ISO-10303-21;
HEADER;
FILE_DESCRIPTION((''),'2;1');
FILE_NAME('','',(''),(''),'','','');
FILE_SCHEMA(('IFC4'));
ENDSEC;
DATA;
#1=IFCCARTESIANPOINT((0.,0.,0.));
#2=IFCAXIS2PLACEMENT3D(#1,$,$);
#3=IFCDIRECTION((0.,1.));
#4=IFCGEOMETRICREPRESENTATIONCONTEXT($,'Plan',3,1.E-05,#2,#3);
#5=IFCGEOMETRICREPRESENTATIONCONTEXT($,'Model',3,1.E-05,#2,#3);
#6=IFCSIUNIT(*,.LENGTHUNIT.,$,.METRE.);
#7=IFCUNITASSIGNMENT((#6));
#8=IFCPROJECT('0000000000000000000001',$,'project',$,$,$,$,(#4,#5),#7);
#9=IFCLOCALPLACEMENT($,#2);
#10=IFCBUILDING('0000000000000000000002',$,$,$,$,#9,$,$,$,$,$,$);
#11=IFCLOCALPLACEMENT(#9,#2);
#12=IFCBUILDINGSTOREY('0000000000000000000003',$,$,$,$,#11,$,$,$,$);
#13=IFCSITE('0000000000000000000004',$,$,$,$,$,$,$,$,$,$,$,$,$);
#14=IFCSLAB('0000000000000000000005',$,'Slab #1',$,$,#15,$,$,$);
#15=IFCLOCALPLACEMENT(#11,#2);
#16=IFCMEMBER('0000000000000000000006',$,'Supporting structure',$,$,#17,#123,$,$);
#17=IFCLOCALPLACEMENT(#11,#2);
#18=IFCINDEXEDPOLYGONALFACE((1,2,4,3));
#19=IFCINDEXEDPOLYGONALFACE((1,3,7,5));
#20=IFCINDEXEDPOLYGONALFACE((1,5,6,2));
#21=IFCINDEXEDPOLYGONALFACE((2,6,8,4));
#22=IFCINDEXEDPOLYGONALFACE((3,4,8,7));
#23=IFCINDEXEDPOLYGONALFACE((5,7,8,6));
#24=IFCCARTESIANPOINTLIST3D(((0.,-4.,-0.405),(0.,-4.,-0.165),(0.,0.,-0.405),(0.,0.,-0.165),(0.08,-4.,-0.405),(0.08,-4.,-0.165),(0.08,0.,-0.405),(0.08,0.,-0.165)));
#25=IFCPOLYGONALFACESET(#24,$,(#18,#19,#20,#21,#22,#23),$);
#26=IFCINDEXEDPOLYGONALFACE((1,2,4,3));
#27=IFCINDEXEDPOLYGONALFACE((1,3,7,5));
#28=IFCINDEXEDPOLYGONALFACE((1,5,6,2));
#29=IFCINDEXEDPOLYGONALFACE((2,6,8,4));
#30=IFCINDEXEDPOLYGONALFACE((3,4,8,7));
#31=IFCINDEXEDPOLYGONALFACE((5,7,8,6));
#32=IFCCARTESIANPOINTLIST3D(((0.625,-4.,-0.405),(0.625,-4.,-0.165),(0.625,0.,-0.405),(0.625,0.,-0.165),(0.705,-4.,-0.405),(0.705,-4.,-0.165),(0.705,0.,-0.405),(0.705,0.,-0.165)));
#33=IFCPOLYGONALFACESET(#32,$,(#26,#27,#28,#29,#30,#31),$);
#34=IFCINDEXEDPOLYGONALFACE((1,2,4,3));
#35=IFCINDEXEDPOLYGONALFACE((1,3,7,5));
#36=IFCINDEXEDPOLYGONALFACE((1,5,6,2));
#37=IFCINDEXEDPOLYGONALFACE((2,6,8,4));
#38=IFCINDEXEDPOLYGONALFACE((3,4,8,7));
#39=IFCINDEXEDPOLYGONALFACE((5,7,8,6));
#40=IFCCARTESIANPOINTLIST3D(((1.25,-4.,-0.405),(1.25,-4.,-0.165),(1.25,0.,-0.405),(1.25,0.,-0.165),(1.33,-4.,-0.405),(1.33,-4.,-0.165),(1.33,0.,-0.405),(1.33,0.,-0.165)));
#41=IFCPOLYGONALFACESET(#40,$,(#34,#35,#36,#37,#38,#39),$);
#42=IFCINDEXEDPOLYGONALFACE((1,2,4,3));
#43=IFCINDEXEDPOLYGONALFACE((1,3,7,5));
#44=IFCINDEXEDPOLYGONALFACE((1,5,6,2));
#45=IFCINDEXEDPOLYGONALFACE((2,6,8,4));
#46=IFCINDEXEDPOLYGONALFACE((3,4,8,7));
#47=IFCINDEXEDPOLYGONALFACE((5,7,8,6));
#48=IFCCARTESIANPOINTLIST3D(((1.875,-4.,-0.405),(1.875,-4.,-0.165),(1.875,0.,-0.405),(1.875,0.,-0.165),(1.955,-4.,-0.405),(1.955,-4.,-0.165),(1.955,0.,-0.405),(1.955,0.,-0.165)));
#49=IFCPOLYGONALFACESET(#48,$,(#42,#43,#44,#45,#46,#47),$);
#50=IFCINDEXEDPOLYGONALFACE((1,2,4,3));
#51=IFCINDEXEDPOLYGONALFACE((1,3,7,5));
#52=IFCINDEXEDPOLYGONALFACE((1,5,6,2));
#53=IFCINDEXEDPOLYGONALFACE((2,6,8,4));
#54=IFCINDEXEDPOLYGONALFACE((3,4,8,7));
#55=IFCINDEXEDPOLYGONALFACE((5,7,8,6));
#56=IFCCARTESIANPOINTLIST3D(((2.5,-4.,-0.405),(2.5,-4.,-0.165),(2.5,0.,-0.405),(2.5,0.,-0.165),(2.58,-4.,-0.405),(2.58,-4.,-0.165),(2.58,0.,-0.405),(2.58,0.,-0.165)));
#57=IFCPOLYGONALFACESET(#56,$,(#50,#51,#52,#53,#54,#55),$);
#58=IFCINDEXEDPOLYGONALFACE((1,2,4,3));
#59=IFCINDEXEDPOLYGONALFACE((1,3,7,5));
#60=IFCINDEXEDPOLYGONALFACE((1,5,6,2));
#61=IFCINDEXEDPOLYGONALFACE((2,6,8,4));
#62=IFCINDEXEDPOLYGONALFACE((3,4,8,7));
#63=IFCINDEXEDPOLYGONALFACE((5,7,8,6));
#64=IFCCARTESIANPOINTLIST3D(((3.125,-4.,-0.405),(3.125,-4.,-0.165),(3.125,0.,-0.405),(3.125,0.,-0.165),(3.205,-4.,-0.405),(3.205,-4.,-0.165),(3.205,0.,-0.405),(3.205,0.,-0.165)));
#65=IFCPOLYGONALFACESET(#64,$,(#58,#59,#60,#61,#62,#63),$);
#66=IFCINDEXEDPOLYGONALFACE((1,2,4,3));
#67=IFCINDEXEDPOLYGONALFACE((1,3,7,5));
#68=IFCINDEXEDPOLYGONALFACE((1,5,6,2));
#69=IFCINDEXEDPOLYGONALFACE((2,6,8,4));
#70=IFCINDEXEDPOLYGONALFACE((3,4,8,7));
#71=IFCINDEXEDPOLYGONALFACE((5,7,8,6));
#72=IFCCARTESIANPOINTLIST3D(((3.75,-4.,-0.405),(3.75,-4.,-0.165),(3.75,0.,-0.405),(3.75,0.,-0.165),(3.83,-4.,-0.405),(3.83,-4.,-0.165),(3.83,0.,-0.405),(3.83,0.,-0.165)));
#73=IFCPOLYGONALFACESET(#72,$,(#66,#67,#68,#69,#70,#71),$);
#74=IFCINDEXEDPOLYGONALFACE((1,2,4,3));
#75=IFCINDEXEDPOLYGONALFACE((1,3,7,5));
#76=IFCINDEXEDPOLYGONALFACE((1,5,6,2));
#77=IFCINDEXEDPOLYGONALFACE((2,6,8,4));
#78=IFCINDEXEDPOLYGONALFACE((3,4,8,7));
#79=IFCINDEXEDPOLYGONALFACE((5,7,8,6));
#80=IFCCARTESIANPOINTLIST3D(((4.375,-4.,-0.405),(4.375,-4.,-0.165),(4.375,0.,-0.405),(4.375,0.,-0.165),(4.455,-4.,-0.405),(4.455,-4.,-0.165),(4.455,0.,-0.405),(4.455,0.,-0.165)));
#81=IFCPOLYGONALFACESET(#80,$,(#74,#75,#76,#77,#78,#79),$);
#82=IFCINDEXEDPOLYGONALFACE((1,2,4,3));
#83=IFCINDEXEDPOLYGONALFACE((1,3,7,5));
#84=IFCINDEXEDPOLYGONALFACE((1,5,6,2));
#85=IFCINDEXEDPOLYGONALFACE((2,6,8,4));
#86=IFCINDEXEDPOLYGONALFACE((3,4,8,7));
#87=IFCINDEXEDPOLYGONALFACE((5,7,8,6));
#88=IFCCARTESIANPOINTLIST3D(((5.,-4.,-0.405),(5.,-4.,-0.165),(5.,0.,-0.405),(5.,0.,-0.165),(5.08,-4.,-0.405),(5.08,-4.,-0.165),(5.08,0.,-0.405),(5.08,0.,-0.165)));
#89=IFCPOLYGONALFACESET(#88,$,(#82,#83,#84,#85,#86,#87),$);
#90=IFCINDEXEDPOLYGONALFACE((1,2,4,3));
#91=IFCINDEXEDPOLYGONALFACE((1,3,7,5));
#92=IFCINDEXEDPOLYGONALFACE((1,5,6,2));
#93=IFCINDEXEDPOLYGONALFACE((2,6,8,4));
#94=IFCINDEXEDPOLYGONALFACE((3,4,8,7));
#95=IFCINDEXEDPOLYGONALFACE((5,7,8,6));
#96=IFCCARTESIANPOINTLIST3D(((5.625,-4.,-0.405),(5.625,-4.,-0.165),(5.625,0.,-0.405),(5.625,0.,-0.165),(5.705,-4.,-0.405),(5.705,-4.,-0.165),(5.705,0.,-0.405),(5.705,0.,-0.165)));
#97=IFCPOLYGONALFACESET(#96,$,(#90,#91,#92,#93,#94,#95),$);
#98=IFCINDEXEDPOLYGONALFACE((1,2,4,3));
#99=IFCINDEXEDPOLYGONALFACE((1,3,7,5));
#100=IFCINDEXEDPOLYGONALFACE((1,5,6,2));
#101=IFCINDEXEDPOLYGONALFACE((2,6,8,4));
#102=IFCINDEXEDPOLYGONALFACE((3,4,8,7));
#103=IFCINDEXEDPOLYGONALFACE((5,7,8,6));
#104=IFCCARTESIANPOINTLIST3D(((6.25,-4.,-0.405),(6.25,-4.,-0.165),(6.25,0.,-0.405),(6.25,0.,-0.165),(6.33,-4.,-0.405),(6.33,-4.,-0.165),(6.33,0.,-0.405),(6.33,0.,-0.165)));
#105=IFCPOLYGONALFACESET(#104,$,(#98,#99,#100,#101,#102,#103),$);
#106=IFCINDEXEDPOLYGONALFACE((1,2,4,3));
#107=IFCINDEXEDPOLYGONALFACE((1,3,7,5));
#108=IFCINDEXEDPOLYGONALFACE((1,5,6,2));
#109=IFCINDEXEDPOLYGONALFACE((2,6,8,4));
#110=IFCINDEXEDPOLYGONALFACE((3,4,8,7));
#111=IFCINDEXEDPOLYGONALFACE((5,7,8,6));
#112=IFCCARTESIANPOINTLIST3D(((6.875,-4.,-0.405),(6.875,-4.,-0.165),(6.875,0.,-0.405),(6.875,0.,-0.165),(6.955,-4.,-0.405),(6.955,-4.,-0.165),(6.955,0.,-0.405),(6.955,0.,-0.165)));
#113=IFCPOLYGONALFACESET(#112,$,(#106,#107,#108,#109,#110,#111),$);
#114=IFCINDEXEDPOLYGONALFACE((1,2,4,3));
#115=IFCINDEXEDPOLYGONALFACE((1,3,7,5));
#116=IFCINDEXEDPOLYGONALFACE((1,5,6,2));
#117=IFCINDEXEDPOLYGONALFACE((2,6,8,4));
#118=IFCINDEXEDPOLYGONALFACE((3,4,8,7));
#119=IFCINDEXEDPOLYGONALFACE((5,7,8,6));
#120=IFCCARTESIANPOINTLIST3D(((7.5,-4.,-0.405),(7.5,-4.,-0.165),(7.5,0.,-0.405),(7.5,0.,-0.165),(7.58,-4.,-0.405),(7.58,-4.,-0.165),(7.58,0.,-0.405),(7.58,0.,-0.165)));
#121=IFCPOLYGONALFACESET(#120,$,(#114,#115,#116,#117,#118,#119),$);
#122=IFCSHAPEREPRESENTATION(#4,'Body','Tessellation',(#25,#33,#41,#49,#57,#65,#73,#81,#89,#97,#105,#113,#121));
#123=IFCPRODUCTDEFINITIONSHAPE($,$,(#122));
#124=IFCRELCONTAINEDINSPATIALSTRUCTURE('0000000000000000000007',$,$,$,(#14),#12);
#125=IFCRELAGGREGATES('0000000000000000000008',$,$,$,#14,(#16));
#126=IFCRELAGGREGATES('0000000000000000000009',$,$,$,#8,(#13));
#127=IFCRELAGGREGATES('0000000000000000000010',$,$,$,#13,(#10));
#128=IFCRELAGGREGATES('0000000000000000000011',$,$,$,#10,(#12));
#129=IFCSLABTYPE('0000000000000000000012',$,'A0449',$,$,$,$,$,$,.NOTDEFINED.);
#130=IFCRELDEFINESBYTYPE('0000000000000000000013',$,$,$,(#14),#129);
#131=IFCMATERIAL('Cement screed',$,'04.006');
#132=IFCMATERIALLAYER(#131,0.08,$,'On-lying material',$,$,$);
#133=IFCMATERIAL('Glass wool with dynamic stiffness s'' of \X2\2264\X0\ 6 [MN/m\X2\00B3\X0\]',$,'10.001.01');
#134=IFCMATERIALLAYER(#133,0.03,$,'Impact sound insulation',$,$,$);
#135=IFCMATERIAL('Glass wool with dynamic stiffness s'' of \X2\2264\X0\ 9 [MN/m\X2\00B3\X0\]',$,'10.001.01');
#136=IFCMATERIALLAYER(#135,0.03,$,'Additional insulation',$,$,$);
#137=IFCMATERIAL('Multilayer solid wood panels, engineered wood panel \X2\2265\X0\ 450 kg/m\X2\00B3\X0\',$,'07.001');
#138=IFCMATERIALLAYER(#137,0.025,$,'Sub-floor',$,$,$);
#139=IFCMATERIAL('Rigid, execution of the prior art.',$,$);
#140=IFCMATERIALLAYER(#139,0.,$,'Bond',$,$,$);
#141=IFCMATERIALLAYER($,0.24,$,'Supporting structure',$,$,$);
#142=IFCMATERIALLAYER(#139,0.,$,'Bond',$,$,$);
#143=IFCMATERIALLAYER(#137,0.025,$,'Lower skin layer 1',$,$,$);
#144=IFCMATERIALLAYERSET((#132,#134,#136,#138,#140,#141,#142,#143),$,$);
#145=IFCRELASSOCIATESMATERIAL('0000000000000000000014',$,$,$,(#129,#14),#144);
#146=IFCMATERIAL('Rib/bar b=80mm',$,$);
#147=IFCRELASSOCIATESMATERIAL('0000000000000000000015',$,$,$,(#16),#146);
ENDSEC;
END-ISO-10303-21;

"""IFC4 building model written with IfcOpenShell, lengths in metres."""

from ifc_helpers import new_model, si_unit, direction, frame, frame_2d, origin, place, context, project, spatial, rectangle, extrude, material, layer, layer_set, type_object, element, aggregate, save


model = new_model("IFC4")

# Units and contexts
plan_context = context("Plan", 3, precision=1e-05, world=origin(), true_north=direction((0.0, 1.0)))
model_context = context("Model", 3, precision=1e-05, world=origin(), true_north=direction((0.0, 1.0)))
ifc_project = project(units=[si_unit("LENGTHUNIT", "METRE")], contexts=[plan_context, model_context])

# Site, building, storey
site = spatial("IfcSite", under=ifc_project)
building_placement = place(None, origin())
building = spatial("IfcBuilding", under=site, at=building_placement)
storey_placement = place(building_placement, origin())
storey = spatial("IfcBuildingStorey", under=building, at=storey_placement)

# Slab, member
ifc_material_1 = material(Name="Cement screed", Category="04.006")
ifc_layer_1 = layer(ifc_material_1, 0.08, Name="On-lying material")
ifc_material_2 = material(Name="Glass wool with dynamic stiffness s' of ≤ 6 [MN/m³]", Category="10.001.01")
ifc_layer_2 = layer(ifc_material_2, 0.03, Name="Impact sound insulation")
ifc_material_3 = material(Name="Glass wool with dynamic stiffness s' of ≤ 9 [MN/m³]", Category="10.001.01")
ifc_layer_3 = layer(ifc_material_3, 0.03, Name="Additional insulation")
ifc_material_4 = material(Name="Multilayer solid wood panels, engineered wood panel ≥ 450 kg/m³", Category="07.001")
ifc_layer_4 = layer(ifc_material_4, 0.025, Name="Sub-floor")
ifc_material_5 = material(Name="Rigid, execution of the prior art.")
ifc_layer_5 = layer(ifc_material_5, 0.0, Name="Bond")
ifc_layer_6 = layer(None, 0.24, Name="Supporting structure")
ifc_layer_7 = layer(ifc_material_5, 0.0, Name="Bond")
ifc_layer_8 = layer(ifc_material_4, 0.025, Name="Lower skin layer 1")
ifc_layer_set = layer_set([ifc_layer_1, ifc_layer_2, ifc_layer_3, ifc_layer_4, ifc_layer_5, ifc_layer_6, ifc_layer_7, ifc_layer_8])
slab_type = type_object("IfcSlabType", Name="A0449", PredefinedType="NOTDEFINED", material=ifc_layer_set)
slab_placement = place(None, frame((0.0, 0.0, 0.0), z_axis=(0.0, 0.0, -1.0), x_axis=(1.0, 0.0, 0.0)))
slab = element("IfcSlab", 1, at=slab_placement, inside=storey, type_object=slab_type, material=ifc_layer_set, Name="Slab #1")
ifc_material_6 = material(Name="Rib/bar b=80mm")
member_1_placement = place(slab_placement, origin())
member_1 = element("IfcMember", 2, at=member_1_placement, material=ifc_material_6, Name="Supporting structure", context=plan_context, shape_type="SweptSolid", body=[
    extrude(rectangle(XDim=0.08, YDim=0.24, at=frame_2d((0.04, 0.12), x_axis=(1.0, 0.0))), frame((0.0, 4.0, 0.165), z_axis=(0.0, -1.0, 0.0), x_axis=(1.0, 0.0, 0.0)), (0.0, 0.0, 1.0), 4.0),
    extrude(rectangle(XDim=0.08, YDim=0.24, at=frame_2d((0.04, 0.12), x_axis=(1.0, 0.0))), frame((0.625, 4.0, 0.165), z_axis=(0.0, -1.0, 0.0), x_axis=(1.0, 0.0, 0.0)), (0.0, 0.0, 1.0), 4.0),
    extrude(rectangle(XDim=0.08, YDim=0.24, at=frame_2d((0.04, 0.12), x_axis=(1.0, 0.0))), frame((1.25, 4.0, 0.165), z_axis=(0.0, -1.0, 0.0), x_axis=(1.0, 0.0, 0.0)), (0.0, 0.0, 1.0), 4.0),
    extrude(rectangle(XDim=0.08, YDim=0.24, at=frame_2d((0.04, 0.12), x_axis=(1.0, 0.0))), frame((1.875, 4.0, 0.165), z_axis=(0.0, -1.0, 0.0), x_axis=(1.0, 0.0, 0.0)), (0.0, 0.0, 1.0), 4.0),
    extrude(rectangle(XDim=0.08, YDim=0.24, at=frame_2d((0.04, 0.12), x_axis=(1.0, 0.0))), frame((2.5, 4.0, 0.165), z_axis=(0.0, -1.0, 0.0), x_axis=(1.0, 0.0, 0.0)), (0.0, 0.0, 1.0), 4.0),
    extrude(rectangle(XDim=0.08, YDim=0.24, at=frame_2d((0.04, 0.12), x_axis=(1.0, 0.0))), frame((3.125, 4.0, 0.165), z_axis=(0.0, -1.0, 0.0), x_axis=(1.0, 0.0, 0.0)), (0.0, 0.0, 1.0), 4.0),
    extrude(rectangle(XDim=0.08, YDim=0.24, at=frame_2d((0.04, 0.12), x_axis=(1.0, 0.0))), frame((3.75, 4.0, 0.165), z_axis=(0.0, -1.0, 0.0), x_axis=(1.0, 0.0, 0.0)), (0.0, 0.0, 1.0), 4.0),
    extrude(rectangle(XDim=0.08, YDim=0.24, at=frame_2d((0.04, 0.12), x_axis=(1.0, 0.0))), frame((4.375, 4.0, 0.165), z_axis=(0.0, -1.0, 0.0), x_axis=(1.0, 0.0, 0.0)), (0.0, 0.0, 1.0), 4.0),
    extrude(rectangle(XDim=0.08, YDim=0.24, at=frame_2d((0.04, 0.12), x_axis=(1.0, 0.0))), frame((5.0, 4.0, 0.165), z_axis=(0.0, -1.0, 0.0), x_axis=(1.0, 0.0, 0.0)), (0.0, 0.0, 1.0), 4.0),
    extrude(rectangle(XDim=0.08, YDim=0.24, at=frame_2d((0.04, 0.12), x_axis=(1.0, 0.0))), frame((5.625, 4.0, 0.165), z_axis=(0.0, -1.0, 0.0), x_axis=(1.0, 0.0, 0.0)), (0.0, 0.0, 1.0), 4.0),
    extrude(rectangle(XDim=0.08, YDim=0.24, at=frame_2d((0.04, 0.12), x_axis=(1.0, 0.0))), frame((6.25, 4.0, 0.165), z_axis=(0.0, -1.0, 0.0), x_axis=(1.0, 0.0, 0.0)), (0.0, 0.0, 1.0), 4.0),
    extrude(rectangle(XDim=0.08, YDim=0.24, at=frame_2d((0.04, 0.12), x_axis=(1.0, 0.0))), frame((6.875, 4.0, 0.165), z_axis=(0.0, -1.0, 0.0), x_axis=(1.0, 0.0, 0.0)), (0.0, 0.0, 1.0), 4.0),
    extrude(rectangle(XDim=0.08, YDim=0.24, at=frame_2d((0.04, 0.12), x_axis=(1.0, 0.0))), frame((7.5, 4.0, 0.165), z_axis=(0.0, -1.0, 0.0), x_axis=(1.0, 0.0, 0.0)), (0.0, 0.0, 1.0), 4.0),
])
aggregate(slab, [member_1])

save(model, "model.ifc")
